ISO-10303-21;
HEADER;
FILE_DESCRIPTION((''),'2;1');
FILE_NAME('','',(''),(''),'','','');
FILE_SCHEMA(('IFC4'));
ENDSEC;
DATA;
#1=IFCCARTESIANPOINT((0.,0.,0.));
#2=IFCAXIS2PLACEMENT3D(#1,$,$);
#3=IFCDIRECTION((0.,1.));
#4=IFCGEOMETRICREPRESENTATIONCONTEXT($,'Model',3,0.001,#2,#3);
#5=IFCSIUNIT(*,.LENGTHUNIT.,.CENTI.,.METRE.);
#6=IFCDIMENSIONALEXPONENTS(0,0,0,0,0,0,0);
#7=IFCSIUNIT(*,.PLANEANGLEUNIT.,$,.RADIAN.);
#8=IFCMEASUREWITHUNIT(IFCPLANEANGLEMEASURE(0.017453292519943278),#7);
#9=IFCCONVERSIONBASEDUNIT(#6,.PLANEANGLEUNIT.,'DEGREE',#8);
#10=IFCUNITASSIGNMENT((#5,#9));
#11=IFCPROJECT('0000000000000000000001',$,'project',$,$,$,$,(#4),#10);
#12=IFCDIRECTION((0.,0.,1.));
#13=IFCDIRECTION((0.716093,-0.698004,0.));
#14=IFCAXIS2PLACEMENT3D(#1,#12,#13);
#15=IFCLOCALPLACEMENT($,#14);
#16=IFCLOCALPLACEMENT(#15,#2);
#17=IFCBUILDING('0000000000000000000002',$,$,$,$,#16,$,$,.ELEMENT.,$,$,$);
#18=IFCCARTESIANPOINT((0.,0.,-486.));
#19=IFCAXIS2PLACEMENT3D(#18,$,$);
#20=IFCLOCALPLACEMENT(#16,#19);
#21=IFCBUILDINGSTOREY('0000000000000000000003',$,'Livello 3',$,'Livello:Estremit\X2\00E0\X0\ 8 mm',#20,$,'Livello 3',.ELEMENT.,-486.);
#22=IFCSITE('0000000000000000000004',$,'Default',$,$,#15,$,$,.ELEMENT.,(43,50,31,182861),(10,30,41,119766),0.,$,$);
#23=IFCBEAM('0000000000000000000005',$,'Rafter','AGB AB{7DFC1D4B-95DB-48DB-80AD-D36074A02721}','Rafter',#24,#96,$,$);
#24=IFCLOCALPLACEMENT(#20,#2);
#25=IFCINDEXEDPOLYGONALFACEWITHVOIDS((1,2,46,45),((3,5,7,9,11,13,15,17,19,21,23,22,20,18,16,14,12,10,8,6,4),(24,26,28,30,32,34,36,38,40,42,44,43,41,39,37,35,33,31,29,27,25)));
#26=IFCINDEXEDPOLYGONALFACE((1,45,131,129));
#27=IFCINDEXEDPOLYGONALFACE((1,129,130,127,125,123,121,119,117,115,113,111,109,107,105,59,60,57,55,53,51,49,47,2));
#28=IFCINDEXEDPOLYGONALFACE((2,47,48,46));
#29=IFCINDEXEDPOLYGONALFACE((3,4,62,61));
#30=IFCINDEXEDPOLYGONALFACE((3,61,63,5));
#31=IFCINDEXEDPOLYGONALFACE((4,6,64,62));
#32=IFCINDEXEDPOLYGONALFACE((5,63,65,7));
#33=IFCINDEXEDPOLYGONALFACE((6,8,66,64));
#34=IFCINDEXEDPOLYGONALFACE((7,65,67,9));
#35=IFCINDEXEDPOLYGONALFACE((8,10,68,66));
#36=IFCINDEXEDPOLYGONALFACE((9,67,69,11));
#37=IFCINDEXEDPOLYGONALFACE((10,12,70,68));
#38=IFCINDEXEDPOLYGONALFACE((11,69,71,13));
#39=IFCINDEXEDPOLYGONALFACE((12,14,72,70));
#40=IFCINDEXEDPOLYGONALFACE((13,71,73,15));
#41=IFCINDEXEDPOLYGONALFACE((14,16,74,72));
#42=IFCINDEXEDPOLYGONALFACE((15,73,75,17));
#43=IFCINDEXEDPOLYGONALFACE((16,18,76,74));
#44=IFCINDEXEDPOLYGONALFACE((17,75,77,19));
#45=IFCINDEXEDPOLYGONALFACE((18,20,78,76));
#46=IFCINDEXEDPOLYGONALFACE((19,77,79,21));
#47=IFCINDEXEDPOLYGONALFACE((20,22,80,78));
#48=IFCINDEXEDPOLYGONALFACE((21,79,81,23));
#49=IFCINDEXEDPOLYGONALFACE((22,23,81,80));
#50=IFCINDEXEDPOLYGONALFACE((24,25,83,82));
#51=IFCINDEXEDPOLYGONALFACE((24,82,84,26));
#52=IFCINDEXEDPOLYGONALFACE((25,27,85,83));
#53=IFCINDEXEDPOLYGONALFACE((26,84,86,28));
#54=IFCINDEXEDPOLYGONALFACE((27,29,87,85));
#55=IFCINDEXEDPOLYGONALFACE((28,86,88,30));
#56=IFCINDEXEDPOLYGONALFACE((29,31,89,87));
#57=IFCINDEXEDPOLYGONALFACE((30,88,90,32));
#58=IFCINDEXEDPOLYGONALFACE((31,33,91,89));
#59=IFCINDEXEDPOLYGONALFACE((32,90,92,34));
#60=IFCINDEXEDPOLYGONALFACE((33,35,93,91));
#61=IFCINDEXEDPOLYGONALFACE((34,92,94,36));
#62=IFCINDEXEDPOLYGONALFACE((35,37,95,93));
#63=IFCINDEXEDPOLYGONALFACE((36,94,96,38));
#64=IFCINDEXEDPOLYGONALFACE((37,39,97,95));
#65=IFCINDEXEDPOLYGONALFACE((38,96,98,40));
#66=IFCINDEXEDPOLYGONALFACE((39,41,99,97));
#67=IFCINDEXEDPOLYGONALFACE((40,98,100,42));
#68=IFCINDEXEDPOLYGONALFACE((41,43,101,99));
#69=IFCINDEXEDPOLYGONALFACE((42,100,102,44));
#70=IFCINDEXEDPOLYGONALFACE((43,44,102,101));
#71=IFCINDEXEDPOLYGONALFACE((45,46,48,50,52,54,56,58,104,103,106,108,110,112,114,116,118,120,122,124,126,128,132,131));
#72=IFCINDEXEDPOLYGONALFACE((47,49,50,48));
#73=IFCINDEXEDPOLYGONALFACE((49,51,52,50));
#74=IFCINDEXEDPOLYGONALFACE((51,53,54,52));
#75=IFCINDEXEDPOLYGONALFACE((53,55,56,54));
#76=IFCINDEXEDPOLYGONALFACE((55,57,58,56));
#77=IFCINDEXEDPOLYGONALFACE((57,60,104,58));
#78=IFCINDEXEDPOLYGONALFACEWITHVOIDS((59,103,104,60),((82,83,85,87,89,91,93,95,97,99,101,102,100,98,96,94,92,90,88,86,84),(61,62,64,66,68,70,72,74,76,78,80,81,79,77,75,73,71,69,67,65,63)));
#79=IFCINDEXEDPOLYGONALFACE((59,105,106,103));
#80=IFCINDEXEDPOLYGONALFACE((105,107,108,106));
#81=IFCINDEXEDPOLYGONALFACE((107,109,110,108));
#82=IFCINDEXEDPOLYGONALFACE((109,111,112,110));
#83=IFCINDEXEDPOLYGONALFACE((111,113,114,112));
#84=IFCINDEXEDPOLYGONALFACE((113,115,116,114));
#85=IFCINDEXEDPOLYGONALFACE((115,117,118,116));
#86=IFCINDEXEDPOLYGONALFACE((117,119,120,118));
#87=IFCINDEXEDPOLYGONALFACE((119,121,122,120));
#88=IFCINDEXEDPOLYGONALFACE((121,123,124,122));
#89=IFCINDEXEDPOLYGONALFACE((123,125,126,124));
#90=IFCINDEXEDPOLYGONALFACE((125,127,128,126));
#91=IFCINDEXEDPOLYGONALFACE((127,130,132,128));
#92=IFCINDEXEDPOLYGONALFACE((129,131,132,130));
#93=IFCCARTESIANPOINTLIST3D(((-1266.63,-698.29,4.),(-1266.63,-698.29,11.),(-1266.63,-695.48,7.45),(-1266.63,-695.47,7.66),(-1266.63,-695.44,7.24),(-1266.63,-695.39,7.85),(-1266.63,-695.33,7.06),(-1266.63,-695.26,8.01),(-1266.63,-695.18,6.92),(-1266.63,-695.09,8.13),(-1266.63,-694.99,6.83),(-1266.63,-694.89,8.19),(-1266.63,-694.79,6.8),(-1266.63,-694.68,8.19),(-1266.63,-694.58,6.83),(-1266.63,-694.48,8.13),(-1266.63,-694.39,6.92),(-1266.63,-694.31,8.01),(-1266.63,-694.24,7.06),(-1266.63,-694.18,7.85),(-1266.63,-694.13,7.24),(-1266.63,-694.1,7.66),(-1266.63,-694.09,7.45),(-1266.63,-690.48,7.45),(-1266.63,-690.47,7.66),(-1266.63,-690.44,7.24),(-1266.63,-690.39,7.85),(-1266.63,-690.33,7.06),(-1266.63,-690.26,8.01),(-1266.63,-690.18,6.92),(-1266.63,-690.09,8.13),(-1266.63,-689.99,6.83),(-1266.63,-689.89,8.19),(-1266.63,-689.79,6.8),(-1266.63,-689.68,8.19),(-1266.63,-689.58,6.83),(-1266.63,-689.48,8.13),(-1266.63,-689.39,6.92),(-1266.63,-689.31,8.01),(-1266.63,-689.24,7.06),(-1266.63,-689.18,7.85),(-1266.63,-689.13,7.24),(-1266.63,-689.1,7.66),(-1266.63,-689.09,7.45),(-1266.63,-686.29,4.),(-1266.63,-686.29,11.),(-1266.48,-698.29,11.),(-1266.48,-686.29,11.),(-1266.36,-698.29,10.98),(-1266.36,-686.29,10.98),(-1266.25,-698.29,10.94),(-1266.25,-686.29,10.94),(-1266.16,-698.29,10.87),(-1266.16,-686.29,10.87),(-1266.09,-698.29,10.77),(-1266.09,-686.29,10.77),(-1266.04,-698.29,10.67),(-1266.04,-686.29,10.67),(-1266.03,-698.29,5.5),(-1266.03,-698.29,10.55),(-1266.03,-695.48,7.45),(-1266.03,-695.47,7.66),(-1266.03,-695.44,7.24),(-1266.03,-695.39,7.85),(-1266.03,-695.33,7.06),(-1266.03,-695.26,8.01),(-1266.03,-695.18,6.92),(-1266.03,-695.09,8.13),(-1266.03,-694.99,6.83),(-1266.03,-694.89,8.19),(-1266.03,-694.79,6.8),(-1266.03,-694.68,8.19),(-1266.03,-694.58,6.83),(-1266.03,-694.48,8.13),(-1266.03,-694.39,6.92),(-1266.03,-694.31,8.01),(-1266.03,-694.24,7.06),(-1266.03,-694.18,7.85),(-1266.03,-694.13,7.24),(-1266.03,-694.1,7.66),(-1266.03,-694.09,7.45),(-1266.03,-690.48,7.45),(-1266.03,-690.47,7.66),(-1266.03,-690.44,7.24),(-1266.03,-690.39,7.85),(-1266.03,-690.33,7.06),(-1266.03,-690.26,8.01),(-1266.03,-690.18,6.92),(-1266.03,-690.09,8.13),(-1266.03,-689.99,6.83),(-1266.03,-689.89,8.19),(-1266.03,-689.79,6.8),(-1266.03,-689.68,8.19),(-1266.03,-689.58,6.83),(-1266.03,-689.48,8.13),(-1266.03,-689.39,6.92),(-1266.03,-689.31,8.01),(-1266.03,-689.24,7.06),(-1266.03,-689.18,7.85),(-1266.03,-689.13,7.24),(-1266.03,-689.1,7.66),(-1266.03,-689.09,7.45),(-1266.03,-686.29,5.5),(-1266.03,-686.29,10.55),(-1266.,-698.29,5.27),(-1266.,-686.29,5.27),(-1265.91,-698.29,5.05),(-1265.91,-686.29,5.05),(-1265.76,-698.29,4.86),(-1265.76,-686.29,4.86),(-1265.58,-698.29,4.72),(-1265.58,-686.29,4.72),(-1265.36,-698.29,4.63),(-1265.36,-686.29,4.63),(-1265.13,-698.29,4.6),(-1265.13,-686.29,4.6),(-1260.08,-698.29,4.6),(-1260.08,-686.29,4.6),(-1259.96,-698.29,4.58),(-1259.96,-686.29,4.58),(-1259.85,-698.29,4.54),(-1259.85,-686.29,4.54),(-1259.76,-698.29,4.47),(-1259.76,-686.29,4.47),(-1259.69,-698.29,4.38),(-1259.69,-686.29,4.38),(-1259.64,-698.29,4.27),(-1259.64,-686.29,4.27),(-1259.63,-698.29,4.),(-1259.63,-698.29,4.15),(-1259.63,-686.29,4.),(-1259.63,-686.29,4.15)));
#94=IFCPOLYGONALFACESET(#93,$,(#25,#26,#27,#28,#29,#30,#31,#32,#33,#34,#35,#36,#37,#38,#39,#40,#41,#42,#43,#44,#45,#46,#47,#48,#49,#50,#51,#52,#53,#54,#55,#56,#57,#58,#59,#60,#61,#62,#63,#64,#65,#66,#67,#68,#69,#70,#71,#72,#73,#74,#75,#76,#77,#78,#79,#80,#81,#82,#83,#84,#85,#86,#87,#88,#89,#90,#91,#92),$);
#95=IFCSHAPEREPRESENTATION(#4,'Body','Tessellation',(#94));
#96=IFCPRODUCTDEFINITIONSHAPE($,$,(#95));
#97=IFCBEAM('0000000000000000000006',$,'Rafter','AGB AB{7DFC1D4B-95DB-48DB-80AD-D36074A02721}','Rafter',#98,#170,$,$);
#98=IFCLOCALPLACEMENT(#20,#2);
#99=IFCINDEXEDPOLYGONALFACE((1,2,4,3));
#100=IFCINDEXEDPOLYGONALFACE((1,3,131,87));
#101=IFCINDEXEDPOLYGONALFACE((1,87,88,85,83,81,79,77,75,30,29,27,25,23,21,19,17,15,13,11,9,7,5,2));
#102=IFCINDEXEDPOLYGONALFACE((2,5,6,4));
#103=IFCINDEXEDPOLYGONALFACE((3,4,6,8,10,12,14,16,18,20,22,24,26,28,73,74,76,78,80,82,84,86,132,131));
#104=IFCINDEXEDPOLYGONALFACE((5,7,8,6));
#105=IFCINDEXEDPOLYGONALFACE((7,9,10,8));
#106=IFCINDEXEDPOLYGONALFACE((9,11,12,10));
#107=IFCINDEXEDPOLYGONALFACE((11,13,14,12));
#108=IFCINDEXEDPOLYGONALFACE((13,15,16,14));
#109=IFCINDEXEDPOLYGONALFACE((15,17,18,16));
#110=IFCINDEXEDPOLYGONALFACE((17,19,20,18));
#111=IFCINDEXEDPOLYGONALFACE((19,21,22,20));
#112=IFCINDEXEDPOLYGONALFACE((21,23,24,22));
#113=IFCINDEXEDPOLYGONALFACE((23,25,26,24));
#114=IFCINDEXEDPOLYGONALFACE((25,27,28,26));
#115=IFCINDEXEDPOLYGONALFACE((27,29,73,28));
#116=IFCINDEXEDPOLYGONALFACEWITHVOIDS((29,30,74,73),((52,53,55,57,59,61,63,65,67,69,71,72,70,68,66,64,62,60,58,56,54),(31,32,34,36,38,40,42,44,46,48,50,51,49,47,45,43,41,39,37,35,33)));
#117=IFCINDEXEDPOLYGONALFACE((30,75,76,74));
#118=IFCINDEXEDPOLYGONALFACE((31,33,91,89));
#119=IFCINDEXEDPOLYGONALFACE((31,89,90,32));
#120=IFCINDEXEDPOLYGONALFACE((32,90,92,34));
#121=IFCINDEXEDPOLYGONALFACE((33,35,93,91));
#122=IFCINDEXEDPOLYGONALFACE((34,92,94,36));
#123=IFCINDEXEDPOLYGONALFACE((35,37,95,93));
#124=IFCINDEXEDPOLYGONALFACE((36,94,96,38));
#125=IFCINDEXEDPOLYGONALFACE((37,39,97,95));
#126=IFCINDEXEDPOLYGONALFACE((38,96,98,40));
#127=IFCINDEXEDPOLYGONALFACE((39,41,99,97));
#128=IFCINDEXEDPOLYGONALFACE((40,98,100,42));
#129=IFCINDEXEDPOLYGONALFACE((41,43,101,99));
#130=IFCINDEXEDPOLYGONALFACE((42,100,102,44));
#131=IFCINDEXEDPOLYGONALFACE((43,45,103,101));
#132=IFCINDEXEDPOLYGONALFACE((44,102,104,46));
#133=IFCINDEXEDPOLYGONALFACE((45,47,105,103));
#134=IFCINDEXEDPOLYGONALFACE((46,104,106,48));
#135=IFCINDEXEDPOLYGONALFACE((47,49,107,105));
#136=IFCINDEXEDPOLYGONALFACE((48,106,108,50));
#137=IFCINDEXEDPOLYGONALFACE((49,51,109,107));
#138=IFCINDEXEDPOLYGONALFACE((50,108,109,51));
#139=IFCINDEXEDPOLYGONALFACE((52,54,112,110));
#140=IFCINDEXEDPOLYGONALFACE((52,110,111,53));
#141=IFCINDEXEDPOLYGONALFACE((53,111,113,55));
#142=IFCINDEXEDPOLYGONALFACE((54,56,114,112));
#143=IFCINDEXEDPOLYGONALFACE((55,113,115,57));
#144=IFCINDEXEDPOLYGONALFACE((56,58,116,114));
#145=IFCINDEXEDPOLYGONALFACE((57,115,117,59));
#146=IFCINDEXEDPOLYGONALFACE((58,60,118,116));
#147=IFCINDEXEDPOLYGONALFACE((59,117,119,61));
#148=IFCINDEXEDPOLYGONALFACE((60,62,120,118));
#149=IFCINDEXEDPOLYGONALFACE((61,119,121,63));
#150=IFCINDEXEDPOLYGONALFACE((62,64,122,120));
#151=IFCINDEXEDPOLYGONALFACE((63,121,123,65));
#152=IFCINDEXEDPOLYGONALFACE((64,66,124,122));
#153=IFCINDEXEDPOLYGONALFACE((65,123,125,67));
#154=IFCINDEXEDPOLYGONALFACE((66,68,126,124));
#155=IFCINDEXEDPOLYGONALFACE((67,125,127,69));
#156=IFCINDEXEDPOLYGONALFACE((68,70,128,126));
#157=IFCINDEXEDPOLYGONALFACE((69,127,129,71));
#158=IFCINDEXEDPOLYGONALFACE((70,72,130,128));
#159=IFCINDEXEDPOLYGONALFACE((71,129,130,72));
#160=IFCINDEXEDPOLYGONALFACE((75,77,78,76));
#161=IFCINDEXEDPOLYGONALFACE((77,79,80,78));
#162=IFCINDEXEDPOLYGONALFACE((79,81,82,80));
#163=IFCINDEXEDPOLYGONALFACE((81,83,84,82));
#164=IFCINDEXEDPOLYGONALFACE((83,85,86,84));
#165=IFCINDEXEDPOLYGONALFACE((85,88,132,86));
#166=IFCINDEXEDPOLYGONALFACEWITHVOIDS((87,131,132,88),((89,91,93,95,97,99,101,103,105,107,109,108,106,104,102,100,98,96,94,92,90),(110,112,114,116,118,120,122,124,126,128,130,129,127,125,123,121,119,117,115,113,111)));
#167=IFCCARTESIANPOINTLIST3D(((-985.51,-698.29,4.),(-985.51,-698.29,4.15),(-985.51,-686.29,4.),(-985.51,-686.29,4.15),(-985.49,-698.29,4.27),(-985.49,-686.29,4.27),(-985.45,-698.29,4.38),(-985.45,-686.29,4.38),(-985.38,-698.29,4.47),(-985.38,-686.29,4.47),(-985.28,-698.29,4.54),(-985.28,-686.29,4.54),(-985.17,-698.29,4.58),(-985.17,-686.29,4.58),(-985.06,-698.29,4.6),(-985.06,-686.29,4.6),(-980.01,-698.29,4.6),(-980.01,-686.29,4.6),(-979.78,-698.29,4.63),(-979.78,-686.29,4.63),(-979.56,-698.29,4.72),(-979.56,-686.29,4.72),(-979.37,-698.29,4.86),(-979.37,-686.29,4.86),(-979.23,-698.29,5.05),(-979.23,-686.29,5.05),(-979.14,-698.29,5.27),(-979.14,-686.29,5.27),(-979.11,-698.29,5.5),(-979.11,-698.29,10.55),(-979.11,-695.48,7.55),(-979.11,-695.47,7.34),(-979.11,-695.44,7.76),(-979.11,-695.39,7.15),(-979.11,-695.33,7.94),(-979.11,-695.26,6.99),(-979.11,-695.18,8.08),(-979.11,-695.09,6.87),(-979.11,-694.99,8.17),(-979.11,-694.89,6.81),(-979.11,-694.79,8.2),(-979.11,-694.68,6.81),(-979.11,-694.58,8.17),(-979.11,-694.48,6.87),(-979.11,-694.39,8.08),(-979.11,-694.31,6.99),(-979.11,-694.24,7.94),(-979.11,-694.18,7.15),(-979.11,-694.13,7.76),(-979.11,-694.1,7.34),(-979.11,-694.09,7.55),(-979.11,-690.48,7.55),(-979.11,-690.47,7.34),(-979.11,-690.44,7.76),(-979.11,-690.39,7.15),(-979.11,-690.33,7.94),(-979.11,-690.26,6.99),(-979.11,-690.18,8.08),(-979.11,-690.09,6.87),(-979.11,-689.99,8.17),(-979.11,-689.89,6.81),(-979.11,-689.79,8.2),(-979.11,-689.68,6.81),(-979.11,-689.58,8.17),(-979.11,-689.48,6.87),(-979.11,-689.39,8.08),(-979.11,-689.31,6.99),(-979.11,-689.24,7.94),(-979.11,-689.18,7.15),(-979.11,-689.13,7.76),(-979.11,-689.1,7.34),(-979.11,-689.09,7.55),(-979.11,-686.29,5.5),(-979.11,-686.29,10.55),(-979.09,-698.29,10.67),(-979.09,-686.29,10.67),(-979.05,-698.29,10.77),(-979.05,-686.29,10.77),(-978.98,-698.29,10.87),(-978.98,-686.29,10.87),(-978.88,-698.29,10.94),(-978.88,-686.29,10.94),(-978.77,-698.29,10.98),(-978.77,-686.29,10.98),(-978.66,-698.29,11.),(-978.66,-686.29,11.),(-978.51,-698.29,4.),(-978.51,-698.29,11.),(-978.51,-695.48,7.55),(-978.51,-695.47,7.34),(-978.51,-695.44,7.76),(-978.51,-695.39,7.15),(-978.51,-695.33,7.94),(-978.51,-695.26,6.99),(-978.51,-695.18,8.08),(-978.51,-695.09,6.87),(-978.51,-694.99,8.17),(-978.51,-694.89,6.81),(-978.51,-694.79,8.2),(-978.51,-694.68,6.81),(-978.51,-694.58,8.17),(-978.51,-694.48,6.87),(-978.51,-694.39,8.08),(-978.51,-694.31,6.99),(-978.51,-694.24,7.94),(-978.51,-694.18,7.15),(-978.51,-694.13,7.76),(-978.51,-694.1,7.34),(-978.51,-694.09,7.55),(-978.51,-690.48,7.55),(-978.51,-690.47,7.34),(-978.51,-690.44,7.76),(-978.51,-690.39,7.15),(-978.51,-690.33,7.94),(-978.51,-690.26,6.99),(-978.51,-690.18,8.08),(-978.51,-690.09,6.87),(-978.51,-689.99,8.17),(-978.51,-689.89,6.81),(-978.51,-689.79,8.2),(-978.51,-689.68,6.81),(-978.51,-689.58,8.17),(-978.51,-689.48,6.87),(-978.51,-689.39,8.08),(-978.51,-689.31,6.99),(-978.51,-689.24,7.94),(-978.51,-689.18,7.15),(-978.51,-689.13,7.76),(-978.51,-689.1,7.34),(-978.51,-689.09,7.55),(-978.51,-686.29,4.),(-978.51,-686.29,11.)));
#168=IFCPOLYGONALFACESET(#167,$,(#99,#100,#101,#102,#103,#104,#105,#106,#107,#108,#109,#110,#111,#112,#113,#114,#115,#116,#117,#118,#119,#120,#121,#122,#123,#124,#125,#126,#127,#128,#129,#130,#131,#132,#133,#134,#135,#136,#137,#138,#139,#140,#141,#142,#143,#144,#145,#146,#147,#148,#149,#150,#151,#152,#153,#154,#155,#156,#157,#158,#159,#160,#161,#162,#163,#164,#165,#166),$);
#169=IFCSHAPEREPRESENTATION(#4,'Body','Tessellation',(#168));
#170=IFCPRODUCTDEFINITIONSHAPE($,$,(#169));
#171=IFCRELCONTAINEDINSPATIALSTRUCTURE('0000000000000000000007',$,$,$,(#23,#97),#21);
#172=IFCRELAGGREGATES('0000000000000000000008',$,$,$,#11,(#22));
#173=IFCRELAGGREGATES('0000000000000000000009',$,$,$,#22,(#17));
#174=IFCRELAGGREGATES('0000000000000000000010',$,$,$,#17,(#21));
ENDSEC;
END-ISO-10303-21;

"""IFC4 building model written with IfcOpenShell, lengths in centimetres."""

from ifc_helpers import new_model, entity, si_unit, converted_unit, direction, frame, frame_2d, origin, place, context, project, spatial, circle, l_section, extrude, element, save


model = new_model("IFC4")

# Units and contexts
model_context = context("Model", 3, precision=0.001, world=origin(), true_north=direction((0.0, 1.0)))
ifc_project = project(units=[si_unit("LENGTHUNIT", "METRE", prefix="CENTI"), converted_unit("PLANEANGLEUNIT", "DEGREE", entity("IfcPlaneAngleMeasure", 0.017453292519943278), si_unit("PLANEANGLEUNIT", "RADIAN"), dimensions=[0, 0, 0, 0, 0, 0, 0])], contexts=[model_context])

# Site, building, storey
site_placement = place(None, frame((0.0, 0.0, 0.0), z_axis=(0.0, 0.0, 1.0), x_axis=(0.716093, -0.698004, 0.0)))
site = spatial("IfcSite", under=ifc_project, at=site_placement, Name="Default", CompositionType="ELEMENT", RefLatitude=(43, 50, 31, 182861), RefLongitude=(10, 30, 41, 119766), RefElevation=0.0)
building_placement = place(site_placement, origin())
building = spatial("IfcBuilding", under=site, at=building_placement, CompositionType="ELEMENT")
storey_placement = place(building_placement, frame((0.0, 0.0, -486.0)))
storey = spatial("IfcBuildingStorey", under=building, at=storey_placement, Name="Livello 3", ObjectType="Livello:Estremità 8 mm", LongName="Livello 3", CompositionType="ELEMENT", Elevation=-486.0)

# Beams, openings
beam_1_placement = place(storey_placement, frame((-1264.7, -698.29, 5.93), z_axis=(0.0, -1.0, 0.0), x_axis=(1.0, 0.0, 0.0)))
beam_1 = element("IfcBeam", 1, at=beam_1_placement, inside=storey, Name="Rafter", Description="AGB AB{7DFC1D4B-95DB-48DB-80AD-D36074A02721}", ObjectType="Rafter", context=model_context, shape_type="SweptSolid", body=[
    extrude(l_section(Depth=7.0, Width=7.0, Thickness=0.6, FilletRadius=0.9, EdgeRadius=0.45, at=frame_2d((1.57, 1.57))), origin(), (0.0, 0.0, -1.0), 12.0),
])
opening_1_placement = place(beam_1_placement, frame((-1.98, 1.57, -4.2), z_axis=(-1.0, 0.0, 0.0), x_axis=(0.0, -1.0, 0.0)))
element("IfcOpeningElement", 2, at=opening_1_placement, cuts=beam_1, ObjectType="Opening", context=model_context, shape_type="SweptSolid", body=[
    extrude(circle(Radius=0.7, at=frame_2d((0.0, 0.7), x_axis=(1.0, 0.0))), origin(), (0.0, 0.0, -1.0), 0.7),
])
opening_2_placement = place(beam_1_placement, frame((-1.98, 1.57, -9.2), z_axis=(-1.0, 0.0, 0.0), x_axis=(0.0, -1.0, 0.0)))
element("IfcOpeningElement", 3, at=opening_2_placement, cuts=beam_1, ObjectType="Opening", context=model_context, shape_type="SweptSolid", body=[
    extrude(circle(Radius=0.7, at=frame_2d((0.0, 0.7), x_axis=(1.0, 0.0))), origin(), (0.0, 0.0, -1.0), 0.7),
])
beam_2_placement = place(storey_placement, frame((-980.44, -686.29, 5.93), z_axis=(0.0, 1.0, 0.0), x_axis=(-1.0, 0.0, 0.0)))
beam_2 = element("IfcBeam", 4, at=beam_2_placement, inside=storey, Name="Rafter", Description="AGB AB{7DFC1D4B-95DB-48DB-80AD-D36074A02721}", ObjectType="Rafter", context=model_context, shape_type="SweptSolid", body=[
    extrude(l_section(Depth=7.0, Width=7.0, Thickness=0.6, FilletRadius=0.9, EdgeRadius=0.45, at=frame_2d((1.57, 1.57))), origin(), (0.0, 0.0, -1.0), 12.0),
])
opening_3_placement = place(beam_2_placement, frame((-1.28, 1.57, -7.8), z_axis=(1.0, 0.0, 0.0), x_axis=(0.0, 1.0, 0.0)))
element("IfcOpeningElement", 5, at=opening_3_placement, cuts=beam_2, ObjectType="Opening", context=model_context, shape_type="SweptSolid", body=[
    extrude(circle(Radius=0.7, at=frame_2d((0.0, -0.7), x_axis=(1.0, 0.0))), origin(), (0.0, 0.0, -1.0), 0.7),
])
opening_4_placement = place(beam_2_placement, frame((-1.28, 1.57, -2.8), z_axis=(1.0, 0.0, 0.0), x_axis=(0.0, 1.0, 0.0)))
element("IfcOpeningElement", 6, at=opening_4_placement, cuts=beam_2, ObjectType="Opening", context=model_context, shape_type="SweptSolid", body=[
    extrude(circle(Radius=0.7, at=frame_2d((0.0, -0.7), x_axis=(1.0, 0.0))), origin(), (0.0, 0.0, -1.0), 0.7),
])

save(model, "model.ifc")
